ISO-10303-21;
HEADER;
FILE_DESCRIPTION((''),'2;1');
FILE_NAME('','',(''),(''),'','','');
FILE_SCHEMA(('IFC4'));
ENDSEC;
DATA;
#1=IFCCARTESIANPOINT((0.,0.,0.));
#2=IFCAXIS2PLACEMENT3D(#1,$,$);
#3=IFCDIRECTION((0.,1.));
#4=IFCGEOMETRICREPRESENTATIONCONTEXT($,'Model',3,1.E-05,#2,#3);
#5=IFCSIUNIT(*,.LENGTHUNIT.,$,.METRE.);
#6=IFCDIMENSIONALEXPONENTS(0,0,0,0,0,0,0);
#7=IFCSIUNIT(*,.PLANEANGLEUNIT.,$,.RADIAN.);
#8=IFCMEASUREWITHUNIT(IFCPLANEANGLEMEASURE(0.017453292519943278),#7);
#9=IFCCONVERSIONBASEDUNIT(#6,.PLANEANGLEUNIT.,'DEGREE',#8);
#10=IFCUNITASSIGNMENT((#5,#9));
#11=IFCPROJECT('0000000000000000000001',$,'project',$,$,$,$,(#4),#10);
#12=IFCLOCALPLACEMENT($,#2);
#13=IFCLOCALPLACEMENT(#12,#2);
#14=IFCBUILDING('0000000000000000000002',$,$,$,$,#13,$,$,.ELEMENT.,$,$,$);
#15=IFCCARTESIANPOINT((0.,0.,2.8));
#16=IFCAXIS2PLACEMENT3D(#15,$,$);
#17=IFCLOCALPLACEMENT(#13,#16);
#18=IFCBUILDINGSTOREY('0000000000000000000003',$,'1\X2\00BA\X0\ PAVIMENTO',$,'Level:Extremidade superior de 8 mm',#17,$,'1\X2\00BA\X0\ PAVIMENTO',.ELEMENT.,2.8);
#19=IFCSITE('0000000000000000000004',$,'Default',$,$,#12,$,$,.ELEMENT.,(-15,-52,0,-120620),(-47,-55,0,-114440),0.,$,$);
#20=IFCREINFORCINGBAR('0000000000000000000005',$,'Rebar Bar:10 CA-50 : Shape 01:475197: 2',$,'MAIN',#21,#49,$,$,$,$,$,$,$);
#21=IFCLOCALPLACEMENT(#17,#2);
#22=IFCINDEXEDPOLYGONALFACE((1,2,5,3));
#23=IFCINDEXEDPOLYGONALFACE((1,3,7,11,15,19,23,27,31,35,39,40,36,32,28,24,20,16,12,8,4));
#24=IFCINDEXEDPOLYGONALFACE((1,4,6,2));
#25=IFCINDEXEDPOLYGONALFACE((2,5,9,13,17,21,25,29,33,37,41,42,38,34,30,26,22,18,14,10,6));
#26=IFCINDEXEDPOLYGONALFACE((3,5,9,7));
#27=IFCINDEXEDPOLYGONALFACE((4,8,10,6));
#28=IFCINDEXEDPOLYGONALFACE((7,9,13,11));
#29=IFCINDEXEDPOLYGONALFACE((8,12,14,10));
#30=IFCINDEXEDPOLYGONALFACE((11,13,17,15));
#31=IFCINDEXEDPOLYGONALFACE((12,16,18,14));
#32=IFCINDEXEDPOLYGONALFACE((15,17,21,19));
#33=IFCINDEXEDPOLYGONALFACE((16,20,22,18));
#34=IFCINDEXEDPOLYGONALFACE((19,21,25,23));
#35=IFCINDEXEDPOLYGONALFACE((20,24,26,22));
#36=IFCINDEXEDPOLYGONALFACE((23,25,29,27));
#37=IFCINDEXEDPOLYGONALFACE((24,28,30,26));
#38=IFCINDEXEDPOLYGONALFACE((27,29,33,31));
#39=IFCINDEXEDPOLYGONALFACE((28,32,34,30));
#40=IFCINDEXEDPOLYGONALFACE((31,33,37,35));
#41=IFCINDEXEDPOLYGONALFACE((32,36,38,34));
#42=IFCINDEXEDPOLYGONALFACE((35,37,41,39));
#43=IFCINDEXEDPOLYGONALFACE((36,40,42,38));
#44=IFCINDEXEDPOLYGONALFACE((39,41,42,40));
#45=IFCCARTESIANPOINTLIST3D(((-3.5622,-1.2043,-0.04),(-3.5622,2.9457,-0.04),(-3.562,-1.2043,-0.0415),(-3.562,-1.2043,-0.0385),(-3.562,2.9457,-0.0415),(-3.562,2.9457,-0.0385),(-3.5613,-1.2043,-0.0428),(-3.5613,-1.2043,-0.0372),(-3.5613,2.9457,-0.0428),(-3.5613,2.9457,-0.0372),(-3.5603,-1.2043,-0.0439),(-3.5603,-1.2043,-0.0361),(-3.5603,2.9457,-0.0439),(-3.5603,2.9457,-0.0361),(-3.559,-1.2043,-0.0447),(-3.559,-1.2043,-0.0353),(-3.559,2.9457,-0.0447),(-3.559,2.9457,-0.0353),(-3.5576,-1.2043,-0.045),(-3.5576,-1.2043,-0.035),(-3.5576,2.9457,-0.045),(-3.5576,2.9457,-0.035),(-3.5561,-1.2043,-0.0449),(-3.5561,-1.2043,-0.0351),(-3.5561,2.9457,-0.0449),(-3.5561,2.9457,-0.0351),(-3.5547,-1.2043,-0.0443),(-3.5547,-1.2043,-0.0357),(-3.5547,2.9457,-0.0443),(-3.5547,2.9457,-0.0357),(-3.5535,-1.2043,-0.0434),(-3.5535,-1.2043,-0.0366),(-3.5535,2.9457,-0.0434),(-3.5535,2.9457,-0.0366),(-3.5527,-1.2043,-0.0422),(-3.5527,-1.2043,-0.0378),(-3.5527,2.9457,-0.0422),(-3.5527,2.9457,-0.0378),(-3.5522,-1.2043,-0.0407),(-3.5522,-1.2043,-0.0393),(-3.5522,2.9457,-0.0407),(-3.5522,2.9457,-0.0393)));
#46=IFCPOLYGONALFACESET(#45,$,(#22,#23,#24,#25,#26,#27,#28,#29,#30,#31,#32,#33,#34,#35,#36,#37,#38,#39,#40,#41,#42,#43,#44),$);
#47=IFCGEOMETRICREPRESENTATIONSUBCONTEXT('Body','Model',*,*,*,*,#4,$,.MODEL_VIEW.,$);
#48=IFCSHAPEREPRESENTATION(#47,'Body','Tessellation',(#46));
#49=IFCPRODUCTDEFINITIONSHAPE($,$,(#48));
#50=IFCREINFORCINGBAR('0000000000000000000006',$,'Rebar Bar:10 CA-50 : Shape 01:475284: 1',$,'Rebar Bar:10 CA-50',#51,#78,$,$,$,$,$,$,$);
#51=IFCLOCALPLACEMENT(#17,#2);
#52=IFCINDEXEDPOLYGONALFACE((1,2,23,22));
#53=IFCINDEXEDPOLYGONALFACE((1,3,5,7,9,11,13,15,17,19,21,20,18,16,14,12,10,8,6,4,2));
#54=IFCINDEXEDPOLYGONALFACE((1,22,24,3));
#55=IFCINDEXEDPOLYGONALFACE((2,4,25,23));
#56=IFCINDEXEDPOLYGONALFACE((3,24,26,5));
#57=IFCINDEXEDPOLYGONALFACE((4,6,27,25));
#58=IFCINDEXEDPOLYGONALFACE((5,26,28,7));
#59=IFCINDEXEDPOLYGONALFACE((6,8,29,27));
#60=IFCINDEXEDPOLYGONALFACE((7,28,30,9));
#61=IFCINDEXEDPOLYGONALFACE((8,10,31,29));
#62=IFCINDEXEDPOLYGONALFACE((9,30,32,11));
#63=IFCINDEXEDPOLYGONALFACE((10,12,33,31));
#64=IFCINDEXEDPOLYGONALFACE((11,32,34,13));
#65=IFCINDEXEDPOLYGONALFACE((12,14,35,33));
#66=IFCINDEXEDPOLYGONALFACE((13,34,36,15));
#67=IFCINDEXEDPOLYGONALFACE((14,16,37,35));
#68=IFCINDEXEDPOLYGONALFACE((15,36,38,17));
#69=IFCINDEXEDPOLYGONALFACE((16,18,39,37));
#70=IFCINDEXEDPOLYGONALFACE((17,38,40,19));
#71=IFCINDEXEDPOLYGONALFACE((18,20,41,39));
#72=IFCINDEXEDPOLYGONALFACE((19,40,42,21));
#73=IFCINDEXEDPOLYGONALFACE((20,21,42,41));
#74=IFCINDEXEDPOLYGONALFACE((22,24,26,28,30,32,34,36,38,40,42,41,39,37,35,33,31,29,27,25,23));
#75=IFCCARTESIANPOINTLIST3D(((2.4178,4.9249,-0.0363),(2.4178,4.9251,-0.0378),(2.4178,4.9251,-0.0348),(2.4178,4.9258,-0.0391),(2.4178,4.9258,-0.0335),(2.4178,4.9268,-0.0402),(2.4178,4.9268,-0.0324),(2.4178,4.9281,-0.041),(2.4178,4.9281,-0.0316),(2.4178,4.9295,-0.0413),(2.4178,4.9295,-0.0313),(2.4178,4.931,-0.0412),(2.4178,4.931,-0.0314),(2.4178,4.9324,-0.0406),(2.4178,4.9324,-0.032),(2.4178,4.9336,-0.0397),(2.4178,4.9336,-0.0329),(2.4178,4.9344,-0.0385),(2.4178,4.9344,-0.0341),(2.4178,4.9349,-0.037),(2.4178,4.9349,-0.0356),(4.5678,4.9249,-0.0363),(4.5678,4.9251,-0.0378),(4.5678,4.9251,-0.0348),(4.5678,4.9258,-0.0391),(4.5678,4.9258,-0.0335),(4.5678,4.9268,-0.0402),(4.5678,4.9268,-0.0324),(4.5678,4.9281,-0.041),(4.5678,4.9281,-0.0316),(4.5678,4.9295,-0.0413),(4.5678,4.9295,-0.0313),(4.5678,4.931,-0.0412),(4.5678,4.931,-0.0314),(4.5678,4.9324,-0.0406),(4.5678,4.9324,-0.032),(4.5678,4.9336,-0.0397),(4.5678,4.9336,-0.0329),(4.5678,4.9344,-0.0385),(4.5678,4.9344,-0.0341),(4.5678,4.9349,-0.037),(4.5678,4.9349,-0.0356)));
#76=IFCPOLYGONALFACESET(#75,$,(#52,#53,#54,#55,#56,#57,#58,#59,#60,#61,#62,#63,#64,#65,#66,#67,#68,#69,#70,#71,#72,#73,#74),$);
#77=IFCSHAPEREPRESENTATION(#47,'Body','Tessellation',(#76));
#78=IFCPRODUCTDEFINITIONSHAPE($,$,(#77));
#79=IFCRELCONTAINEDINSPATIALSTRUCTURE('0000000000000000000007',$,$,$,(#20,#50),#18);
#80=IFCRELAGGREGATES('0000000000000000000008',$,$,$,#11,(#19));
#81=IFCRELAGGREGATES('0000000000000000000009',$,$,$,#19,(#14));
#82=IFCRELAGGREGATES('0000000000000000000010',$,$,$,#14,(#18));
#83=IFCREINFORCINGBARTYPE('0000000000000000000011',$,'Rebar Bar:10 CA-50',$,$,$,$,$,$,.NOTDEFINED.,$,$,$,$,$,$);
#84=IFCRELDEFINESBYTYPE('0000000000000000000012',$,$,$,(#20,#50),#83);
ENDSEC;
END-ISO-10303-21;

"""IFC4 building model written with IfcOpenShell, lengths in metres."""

from ifc_helpers import new_model, entity, si_unit, converted_unit, direction, frame, origin, place, context, subcontext, project, spatial, type_object, element, save


model = new_model("IFC4")

# Units and contexts
model_context = context("Model", 3, precision=1e-05, world=origin(), true_north=direction((0.0, 1.0)))
body_context = subcontext(model_context, "Body", "Model", "MODEL_VIEW")
ifc_project = project(units=[si_unit("LENGTHUNIT", "METRE"), converted_unit("PLANEANGLEUNIT", "DEGREE", entity("IfcPlaneAngleMeasure", 0.017453292519943278), si_unit("PLANEANGLEUNIT", "RADIAN"), dimensions=[0, 0, 0, 0, 0, 0, 0])], contexts=[model_context])

# Site, building, storey
site_placement = place(None, origin())
site = spatial("IfcSite", under=ifc_project, at=site_placement, Name="Default", CompositionType="ELEMENT", RefLatitude=(-15, -52, 0, -120620), RefLongitude=(-47, -55, 0, -114440), RefElevation=0.0)
building_placement = place(site_placement, origin())
building = spatial("IfcBuilding", under=site, at=building_placement, CompositionType="ELEMENT")
storey_placement = place(building_placement, frame((0.0, 0.0, 2.8)))
storey = spatial("IfcBuildingStorey", under=building, at=storey_placement, Name="1º PAVIMENTO", ObjectType="Level:Extremidade superior de 8 mm", LongName="1º PAVIMENTO", CompositionType="ELEMENT", Elevation=2.8)

# Reinforcing bars
reinforcing_bar_type = type_object("IfcReinforcingBarType", Name="Rebar Bar:10 CA-50", PredefinedType="NOTDEFINED")
reinforcing_bar_1_placement = place(storey_placement, origin())
element("IfcReinforcingBar", 1, at=reinforcing_bar_1_placement, inside=storey, type_object=reinforcing_bar_type, Name="Rebar Bar:10 CA-50 : Shape 01:475197: 2", ObjectType="MAIN", context=body_context, shape_type="AdvancedSweptSolid", body=[
    entity("IfcSweptDiskSolid", entity("IfcIndexedPolyCurve", entity("IfcCartesianPointList3D", [[-3.5572, 2.9457, -0.04], [-3.5572, -1.2043, -0.04]]), None, False), 0.005, None, 0.0, 1.0),
])
reinforcing_bar_2_placement = place(storey_placement, origin())
element("IfcReinforcingBar", 2, at=reinforcing_bar_2_placement, inside=storey, type_object=reinforcing_bar_type, Name="Rebar Bar:10 CA-50 : Shape 01:475284: 1", ObjectType="Rebar Bar:10 CA-50", context=body_context, shape_type="AdvancedSweptSolid", body=[
    entity("IfcSweptDiskSolid", entity("IfcIndexedPolyCurve", entity("IfcCartesianPointList3D", [[4.5678, 4.9299, -0.0363], [2.4178, 4.9299, -0.0363]]), None, False), 0.005, None, 0.0, 1.0),
])

save(model, "model.ifc")
